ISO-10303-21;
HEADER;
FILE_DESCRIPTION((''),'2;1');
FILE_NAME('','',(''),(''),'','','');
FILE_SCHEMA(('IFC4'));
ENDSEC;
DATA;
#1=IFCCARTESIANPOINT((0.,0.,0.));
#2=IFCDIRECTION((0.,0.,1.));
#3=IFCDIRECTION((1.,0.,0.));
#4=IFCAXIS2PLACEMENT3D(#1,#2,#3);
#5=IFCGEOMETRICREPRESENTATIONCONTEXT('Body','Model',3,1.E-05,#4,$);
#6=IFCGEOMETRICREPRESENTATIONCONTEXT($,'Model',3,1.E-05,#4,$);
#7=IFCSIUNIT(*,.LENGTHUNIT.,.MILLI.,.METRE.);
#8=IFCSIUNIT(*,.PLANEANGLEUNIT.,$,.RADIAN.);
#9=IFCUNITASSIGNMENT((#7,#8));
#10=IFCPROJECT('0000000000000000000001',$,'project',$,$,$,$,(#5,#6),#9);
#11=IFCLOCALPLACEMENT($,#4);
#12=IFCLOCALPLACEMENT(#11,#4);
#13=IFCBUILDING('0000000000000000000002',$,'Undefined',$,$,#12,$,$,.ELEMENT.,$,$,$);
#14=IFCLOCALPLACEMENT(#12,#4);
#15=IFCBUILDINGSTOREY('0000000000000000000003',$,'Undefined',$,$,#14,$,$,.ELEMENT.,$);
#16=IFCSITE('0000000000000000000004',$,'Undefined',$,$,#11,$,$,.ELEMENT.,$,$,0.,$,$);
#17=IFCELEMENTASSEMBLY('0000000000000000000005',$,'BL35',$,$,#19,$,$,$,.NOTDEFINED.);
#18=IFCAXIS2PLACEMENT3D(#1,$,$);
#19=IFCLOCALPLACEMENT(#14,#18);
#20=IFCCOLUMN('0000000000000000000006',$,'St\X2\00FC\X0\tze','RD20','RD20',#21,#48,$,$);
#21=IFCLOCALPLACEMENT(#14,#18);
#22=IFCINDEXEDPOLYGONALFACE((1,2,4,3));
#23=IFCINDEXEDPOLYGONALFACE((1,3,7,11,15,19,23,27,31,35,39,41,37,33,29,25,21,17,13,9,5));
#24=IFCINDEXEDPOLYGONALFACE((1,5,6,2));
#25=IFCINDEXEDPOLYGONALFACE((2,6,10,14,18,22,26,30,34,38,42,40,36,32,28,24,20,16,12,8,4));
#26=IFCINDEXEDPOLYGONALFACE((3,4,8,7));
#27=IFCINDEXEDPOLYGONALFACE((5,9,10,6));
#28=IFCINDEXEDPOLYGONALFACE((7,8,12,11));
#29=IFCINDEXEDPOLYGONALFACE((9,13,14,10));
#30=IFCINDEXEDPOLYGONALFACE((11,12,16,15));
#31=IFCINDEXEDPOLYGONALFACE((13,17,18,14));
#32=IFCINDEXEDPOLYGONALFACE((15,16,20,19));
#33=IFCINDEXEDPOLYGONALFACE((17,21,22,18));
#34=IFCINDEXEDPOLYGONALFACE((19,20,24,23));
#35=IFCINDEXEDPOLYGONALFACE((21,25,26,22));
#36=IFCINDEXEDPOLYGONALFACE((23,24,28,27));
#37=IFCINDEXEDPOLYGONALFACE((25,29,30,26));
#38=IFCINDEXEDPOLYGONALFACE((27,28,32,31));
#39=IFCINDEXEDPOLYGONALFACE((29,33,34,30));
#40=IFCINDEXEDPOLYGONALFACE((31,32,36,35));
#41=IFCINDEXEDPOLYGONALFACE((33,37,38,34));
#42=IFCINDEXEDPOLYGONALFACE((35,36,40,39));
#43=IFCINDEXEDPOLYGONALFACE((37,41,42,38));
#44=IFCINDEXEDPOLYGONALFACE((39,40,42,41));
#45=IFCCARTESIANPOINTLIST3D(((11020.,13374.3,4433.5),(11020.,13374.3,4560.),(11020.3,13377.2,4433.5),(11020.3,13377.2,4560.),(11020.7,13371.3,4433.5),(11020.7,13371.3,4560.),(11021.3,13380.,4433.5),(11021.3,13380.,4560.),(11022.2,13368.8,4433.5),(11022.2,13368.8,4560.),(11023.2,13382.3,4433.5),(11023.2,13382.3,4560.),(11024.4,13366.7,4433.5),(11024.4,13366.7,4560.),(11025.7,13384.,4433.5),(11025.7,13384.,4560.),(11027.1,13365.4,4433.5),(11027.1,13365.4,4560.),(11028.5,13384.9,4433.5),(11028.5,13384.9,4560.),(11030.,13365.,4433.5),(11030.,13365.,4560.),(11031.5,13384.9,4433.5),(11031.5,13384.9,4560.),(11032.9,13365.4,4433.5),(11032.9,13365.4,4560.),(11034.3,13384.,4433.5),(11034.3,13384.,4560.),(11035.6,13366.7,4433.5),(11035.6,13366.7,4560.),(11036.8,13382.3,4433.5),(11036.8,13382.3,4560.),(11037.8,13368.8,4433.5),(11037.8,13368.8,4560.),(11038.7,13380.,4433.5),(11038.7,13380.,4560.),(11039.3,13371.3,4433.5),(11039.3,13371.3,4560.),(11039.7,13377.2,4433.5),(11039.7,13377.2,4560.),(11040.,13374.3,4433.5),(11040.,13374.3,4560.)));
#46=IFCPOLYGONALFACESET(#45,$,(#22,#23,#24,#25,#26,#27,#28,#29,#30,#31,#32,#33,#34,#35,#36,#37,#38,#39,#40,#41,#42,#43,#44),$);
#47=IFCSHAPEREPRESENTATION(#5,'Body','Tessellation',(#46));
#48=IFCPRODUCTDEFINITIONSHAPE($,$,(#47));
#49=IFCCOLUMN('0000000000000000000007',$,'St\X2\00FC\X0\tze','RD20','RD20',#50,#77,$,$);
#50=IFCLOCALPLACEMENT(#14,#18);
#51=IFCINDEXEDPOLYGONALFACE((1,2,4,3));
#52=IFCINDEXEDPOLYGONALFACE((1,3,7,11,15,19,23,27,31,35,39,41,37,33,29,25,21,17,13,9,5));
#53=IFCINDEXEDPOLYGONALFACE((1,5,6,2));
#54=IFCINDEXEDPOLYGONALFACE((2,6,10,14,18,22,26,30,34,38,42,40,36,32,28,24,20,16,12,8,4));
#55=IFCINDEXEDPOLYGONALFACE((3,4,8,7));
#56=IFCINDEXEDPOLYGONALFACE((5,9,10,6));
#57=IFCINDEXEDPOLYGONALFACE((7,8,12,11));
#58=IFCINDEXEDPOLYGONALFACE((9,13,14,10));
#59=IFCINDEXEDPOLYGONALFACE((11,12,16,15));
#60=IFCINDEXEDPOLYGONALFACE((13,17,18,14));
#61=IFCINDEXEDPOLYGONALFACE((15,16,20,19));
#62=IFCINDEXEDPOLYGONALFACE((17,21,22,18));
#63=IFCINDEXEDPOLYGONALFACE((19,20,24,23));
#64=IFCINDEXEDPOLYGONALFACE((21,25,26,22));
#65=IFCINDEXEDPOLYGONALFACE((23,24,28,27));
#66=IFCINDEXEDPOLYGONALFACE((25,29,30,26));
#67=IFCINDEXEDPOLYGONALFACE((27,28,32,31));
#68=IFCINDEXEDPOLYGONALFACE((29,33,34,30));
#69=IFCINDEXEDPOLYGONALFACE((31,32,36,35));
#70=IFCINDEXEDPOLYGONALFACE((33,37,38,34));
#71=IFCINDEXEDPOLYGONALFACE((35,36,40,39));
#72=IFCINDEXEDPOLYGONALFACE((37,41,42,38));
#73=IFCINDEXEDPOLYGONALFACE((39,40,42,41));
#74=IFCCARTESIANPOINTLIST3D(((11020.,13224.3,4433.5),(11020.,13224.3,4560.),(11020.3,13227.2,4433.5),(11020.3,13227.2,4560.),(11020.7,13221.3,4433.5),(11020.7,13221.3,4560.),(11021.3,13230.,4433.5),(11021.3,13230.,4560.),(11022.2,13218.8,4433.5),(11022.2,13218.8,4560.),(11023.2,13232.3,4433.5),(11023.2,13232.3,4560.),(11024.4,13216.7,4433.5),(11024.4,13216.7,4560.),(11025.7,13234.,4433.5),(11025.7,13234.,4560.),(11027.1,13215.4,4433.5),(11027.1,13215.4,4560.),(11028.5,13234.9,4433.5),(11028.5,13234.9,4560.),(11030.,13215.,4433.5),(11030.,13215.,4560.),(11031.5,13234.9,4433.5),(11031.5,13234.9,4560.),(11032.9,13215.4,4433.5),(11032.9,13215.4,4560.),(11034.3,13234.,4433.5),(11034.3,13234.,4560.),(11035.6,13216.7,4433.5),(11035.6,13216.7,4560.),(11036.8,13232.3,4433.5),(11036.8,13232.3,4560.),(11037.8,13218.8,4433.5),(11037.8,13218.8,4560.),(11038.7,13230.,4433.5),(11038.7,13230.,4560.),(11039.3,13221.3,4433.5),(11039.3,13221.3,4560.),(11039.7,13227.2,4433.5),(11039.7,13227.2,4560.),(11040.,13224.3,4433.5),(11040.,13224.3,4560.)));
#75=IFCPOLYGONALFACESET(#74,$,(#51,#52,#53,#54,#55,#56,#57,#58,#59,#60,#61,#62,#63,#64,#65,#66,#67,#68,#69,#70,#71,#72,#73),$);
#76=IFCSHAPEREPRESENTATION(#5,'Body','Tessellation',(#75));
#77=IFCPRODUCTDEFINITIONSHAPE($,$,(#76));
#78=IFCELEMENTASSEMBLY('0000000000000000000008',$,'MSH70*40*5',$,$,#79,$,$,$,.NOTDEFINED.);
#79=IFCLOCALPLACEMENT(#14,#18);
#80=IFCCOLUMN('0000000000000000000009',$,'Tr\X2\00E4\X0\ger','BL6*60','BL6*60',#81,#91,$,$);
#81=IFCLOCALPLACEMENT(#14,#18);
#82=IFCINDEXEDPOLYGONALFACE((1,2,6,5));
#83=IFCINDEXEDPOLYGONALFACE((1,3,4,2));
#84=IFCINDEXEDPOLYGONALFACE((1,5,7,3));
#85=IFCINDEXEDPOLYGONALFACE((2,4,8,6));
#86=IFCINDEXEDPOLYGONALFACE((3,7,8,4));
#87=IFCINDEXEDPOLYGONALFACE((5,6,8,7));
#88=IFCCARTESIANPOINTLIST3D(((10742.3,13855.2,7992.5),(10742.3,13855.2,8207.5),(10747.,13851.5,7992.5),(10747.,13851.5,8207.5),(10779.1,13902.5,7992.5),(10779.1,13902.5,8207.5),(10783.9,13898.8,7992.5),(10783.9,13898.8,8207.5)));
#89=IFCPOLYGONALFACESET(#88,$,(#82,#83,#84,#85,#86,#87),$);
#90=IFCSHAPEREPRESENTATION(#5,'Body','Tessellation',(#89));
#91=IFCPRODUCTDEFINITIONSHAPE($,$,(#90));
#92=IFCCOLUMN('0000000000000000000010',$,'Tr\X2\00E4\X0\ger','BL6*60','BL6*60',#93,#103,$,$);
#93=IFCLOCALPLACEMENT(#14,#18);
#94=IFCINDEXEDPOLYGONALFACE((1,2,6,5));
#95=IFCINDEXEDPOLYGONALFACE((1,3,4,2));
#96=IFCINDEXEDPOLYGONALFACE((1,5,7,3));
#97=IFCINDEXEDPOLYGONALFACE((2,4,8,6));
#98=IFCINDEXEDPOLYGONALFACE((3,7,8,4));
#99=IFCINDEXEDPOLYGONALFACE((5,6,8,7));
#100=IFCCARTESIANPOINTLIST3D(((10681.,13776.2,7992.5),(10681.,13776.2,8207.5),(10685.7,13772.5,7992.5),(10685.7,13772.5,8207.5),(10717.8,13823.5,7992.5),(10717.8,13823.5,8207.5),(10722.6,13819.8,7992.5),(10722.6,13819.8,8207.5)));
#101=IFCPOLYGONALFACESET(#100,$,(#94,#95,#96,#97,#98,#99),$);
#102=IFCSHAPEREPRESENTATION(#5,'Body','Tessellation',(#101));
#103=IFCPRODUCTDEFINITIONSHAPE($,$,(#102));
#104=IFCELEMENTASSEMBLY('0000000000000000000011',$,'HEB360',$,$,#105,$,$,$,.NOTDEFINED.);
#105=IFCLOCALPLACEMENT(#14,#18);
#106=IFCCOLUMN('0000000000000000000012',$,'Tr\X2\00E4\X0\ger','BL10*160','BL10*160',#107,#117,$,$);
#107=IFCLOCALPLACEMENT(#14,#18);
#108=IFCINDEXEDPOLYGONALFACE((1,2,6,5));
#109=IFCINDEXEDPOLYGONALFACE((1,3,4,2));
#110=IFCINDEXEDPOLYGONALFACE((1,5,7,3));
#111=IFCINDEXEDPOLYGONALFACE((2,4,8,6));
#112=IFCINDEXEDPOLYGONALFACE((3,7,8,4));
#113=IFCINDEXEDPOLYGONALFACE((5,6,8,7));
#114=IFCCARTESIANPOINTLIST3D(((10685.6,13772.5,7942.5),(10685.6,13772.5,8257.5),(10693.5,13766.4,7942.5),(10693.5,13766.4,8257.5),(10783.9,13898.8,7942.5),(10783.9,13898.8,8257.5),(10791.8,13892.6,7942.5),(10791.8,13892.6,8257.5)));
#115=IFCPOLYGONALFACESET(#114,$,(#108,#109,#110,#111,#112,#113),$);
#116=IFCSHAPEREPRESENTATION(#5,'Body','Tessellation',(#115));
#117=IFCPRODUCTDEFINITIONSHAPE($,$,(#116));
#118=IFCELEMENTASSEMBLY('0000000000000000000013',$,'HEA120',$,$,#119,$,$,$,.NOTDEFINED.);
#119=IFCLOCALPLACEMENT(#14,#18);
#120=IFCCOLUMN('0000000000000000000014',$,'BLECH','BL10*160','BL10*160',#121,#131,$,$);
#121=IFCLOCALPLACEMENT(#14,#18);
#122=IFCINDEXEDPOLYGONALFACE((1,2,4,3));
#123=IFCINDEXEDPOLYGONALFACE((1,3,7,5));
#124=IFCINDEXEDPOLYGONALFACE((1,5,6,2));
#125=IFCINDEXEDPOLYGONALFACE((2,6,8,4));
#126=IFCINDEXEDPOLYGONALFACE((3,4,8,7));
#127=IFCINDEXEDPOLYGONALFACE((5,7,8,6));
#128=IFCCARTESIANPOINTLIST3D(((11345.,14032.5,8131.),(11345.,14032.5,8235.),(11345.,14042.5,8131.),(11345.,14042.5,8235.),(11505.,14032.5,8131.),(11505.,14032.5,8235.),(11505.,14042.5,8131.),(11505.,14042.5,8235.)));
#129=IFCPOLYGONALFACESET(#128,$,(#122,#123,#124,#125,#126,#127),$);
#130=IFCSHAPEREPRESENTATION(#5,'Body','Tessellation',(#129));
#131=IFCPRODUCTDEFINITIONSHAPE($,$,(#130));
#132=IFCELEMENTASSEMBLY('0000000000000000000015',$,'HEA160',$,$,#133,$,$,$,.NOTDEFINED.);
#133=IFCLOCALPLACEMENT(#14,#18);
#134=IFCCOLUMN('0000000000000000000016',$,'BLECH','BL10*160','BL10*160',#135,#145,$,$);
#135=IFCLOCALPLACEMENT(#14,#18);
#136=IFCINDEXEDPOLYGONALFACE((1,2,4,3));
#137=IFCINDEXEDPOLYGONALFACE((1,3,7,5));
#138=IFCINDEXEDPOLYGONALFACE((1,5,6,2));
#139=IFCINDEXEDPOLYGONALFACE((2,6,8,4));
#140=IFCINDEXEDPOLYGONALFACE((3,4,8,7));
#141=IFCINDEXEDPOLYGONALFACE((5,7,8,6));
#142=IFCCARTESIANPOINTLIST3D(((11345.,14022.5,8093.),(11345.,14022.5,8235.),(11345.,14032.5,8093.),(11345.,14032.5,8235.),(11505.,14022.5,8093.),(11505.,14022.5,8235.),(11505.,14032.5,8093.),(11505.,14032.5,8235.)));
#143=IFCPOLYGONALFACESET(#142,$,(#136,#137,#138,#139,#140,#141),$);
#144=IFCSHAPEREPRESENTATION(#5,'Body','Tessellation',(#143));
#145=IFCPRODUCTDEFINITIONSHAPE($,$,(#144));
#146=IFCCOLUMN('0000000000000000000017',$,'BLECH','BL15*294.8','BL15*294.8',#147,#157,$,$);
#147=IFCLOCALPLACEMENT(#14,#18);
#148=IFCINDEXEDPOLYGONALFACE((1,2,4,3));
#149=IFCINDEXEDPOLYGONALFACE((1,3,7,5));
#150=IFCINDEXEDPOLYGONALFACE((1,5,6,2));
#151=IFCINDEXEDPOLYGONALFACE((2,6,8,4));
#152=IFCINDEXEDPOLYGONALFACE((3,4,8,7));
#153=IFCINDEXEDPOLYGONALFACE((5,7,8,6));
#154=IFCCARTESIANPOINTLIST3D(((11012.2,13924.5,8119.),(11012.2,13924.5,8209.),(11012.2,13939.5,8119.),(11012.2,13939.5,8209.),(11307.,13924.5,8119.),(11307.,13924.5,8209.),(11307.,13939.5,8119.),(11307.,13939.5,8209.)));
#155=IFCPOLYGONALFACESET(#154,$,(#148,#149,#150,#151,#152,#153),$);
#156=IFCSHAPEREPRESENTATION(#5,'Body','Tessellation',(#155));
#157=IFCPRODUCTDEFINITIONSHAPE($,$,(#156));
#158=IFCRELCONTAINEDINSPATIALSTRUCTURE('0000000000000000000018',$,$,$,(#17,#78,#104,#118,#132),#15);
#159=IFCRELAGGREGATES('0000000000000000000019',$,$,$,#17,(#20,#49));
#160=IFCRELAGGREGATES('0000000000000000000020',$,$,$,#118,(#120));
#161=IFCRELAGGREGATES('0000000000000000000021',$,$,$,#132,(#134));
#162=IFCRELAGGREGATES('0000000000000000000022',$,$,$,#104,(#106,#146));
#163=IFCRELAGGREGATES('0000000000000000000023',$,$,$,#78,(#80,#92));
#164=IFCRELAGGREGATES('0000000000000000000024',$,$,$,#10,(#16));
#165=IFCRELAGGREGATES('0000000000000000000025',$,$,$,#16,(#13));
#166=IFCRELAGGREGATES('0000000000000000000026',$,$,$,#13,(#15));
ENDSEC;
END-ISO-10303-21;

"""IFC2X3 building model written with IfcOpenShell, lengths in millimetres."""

from ifc_helpers import new_model, si_unit, frame, origin_with_axes, origin_2d_with_axis, place, context, project, spatial, rectangle, circle, extrude, element, aggregate, save


model = new_model("IFC2X3")

# Units and contexts
model_context_1 = context("Model", 3, precision=1e-05, world=origin_with_axes(), identifier="Body")
model_context_2 = context("Model", 3, precision=1e-05, world=origin_with_axes())
ifc_project = project(units=[si_unit("LENGTHUNIT", "METRE", prefix="MILLI"), si_unit("PLANEANGLEUNIT", "RADIAN")], contexts=[model_context_1, model_context_2])

# Site, building, storey
site_placement = place(None, origin_with_axes())
site = spatial("IfcSite", under=ifc_project, at=site_placement, Name="Undefined", CompositionType="ELEMENT", RefElevation=0.0)
building_placement = place(site_placement, origin_with_axes())
building = spatial("IfcBuilding", under=site, at=building_placement, Name="Undefined", CompositionType="ELEMENT")
storey_placement = place(building_placement, origin_with_axes())
storey = spatial("IfcBuildingStorey", under=building, at=storey_placement, Name="Undefined", CompositionType="ELEMENT")

# Element assemblies, columns
assembly_1 = element("IfcElementAssembly", 1, inside=storey, Name="BL35", PredefinedType="NOTDEFINED")
column_1_placement = place(storey_placement, frame((11030.0, 13375.0, 4433.5), z_axis=(0.0, 0.0, 1.0), x_axis=(1.0, 0.0, 0.0)))
column_1 = element("IfcColumn", 2, at=column_1_placement, Name="Stütze", Description="RD20", ObjectType="RD20", context=model_context_1, shape_type="SweptSolid", body=[
    extrude(circle(Radius=10.0, at=origin_2d_with_axis()), frame((0.0, 0.0, 126.5), z_axis=(0.0, 0.0, -1.0), x_axis=(0.0, -1.0, 0.0)), (0.0, 0.0, 1.0), 126.5),
])
column_2_placement = place(storey_placement, frame((11030.0, 13225.0, 4433.5), z_axis=(0.0, 0.0, 1.0), x_axis=(1.0, 0.0, 0.0)))
column_2 = element("IfcColumn", 3, at=column_2_placement, Name="Stütze", Description="RD20", ObjectType="RD20", context=model_context_1, shape_type="SweptSolid", body=[
    extrude(circle(Radius=10.0, at=origin_2d_with_axis()), frame((0.0, 0.0, 126.5), z_axis=(0.0, 0.0, -1.0), x_axis=(0.0, -1.0, 0.0)), (0.0, 0.0, 1.0), 126.5),
])
aggregate(assembly_1, [column_1, column_2])
assembly_2 = element("IfcElementAssembly", 4, inside=storey, Name="MSH70*40*5", PredefinedType="NOTDEFINED")
column_3_placement = place(storey_placement, frame((10763.1, 13877.0, 7992.5), z_axis=(0.0, 0.0, 1.0), x_axis=(1.0, 0.0, 0.0)))
column_3 = element("IfcColumn", 5, at=column_3_placement, Name="Träger", Description="BL6*60", ObjectType="BL6*60", context=model_context_1, shape_type="SweptSolid", body=[
    extrude(rectangle(XDim=6.0, YDim=60.0, at=origin_2d_with_axis()), frame((0.0, 0.0, 215.0), z_axis=(0.0, 0.0, -1.0), x_axis=(-0.789084, 0.614285, 0.0)), (0.0, 0.0, 1.0), 215.0),
])
column_4_placement = place(storey_placement, frame((10701.8, 13798.0, 7992.5), z_axis=(0.0, 0.0, 1.0), x_axis=(1.0, 0.0, 0.0)))
column_4 = element("IfcColumn", 6, at=column_4_placement, Name="Träger", Description="BL6*60", ObjectType="BL6*60", context=model_context_1, shape_type="SweptSolid", body=[
    extrude(rectangle(XDim=6.0, YDim=60.0, at=origin_2d_with_axis()), frame((0.0, 0.0, 215.0), z_axis=(0.0, 0.0, -1.0), x_axis=(-0.789084, 0.614285, 0.0)), (0.0, 0.0, 1.0), 215.0),
])

# Element assemblies, columns
assembly_3 = element("IfcElementAssembly", 7, inside=storey, Name="HEB360", PredefinedType="NOTDEFINED")
column_5_placement = place(storey_placement, frame((10738.7, 13832.6, 7942.5), z_axis=(0.0, 0.0, 1.0), x_axis=(1.0, 0.0, 0.0)))
column_5 = element("IfcColumn", 8, at=column_5_placement, Name="Träger", Description="BL10*160", ObjectType="BL10*160", context=model_context_1, shape_type="SweptSolid", body=[
    extrude(rectangle(XDim=10.0, YDim=160.0, at=origin_2d_with_axis()), frame((0.0, 0.0, 315.0), z_axis=(0.0, 0.0, -1.0), x_axis=(-0.789084, 0.614285, 0.0)), (0.0, 0.0, 1.0), 315.0),
])
assembly_4 = element("IfcElementAssembly", 9, inside=storey, Name="HEA120", PredefinedType="NOTDEFINED")
column_6_placement = place(storey_placement, frame((11425.0, 14037.5, 8131.0), z_axis=(0.0, 0.0, 1.0), x_axis=(1.0, 0.0, 0.0)))
column_6 = element("IfcColumn", 10, at=column_6_placement, Name="BLECH", Description="BL10*160", ObjectType="BL10*160", context=model_context_1, shape_type="SweptSolid", body=[
    extrude(rectangle(XDim=10.0, YDim=160.0, at=origin_2d_with_axis()), frame((0.0, 0.0, 104.0), z_axis=(0.0, 0.0, -1.0), x_axis=(0.0, 1.0, 0.0)), (0.0, 0.0, 1.0), 104.0),
])
aggregate(assembly_4, [column_6])
assembly_5 = element("IfcElementAssembly", 11, inside=storey, Name="HEA160", PredefinedType="NOTDEFINED")
column_7_placement = place(storey_placement, frame((11425.0, 14027.5, 8093.0), z_axis=(0.0, 0.0, 1.0), x_axis=(1.0, 0.0, 0.0)))
column_7 = element("IfcColumn", 12, at=column_7_placement, Name="BLECH", Description="BL10*160", ObjectType="BL10*160", context=model_context_1, shape_type="SweptSolid", body=[
    extrude(rectangle(XDim=10.0, YDim=160.0, at=origin_2d_with_axis()), frame((0.0, 0.0, 142.0), z_axis=(0.0, 0.0, -1.0), x_axis=(0.0, 1.0, 0.0)), (0.0, 0.0, 1.0), 142.0),
])
aggregate(assembly_5, [column_7])

# Column
column_8_placement = place(storey_placement, frame((11159.6, 13932.0, 8119.0), z_axis=(0.0, 0.0, 1.0), x_axis=(1.0, 0.0, 0.0)))
column_8 = element("IfcColumn", 13, at=column_8_placement, Name="BLECH", Description="BL15*294.8", ObjectType="BL15*294.8", context=model_context_1, shape_type="SweptSolid", body=[
    extrude(rectangle(XDim=15.0, YDim=294.8, at=origin_2d_with_axis()), frame((0.0, 0.0, 90.0), z_axis=(0.0, 0.0, -1.0), x_axis=(0.0, -1.0, 0.0)), (0.0, 0.0, 1.0), 90.0),
])
aggregate(assembly_3, [column_5, column_8])
aggregate(assembly_2, [column_3, column_4])

save(model, "model.ifc")
